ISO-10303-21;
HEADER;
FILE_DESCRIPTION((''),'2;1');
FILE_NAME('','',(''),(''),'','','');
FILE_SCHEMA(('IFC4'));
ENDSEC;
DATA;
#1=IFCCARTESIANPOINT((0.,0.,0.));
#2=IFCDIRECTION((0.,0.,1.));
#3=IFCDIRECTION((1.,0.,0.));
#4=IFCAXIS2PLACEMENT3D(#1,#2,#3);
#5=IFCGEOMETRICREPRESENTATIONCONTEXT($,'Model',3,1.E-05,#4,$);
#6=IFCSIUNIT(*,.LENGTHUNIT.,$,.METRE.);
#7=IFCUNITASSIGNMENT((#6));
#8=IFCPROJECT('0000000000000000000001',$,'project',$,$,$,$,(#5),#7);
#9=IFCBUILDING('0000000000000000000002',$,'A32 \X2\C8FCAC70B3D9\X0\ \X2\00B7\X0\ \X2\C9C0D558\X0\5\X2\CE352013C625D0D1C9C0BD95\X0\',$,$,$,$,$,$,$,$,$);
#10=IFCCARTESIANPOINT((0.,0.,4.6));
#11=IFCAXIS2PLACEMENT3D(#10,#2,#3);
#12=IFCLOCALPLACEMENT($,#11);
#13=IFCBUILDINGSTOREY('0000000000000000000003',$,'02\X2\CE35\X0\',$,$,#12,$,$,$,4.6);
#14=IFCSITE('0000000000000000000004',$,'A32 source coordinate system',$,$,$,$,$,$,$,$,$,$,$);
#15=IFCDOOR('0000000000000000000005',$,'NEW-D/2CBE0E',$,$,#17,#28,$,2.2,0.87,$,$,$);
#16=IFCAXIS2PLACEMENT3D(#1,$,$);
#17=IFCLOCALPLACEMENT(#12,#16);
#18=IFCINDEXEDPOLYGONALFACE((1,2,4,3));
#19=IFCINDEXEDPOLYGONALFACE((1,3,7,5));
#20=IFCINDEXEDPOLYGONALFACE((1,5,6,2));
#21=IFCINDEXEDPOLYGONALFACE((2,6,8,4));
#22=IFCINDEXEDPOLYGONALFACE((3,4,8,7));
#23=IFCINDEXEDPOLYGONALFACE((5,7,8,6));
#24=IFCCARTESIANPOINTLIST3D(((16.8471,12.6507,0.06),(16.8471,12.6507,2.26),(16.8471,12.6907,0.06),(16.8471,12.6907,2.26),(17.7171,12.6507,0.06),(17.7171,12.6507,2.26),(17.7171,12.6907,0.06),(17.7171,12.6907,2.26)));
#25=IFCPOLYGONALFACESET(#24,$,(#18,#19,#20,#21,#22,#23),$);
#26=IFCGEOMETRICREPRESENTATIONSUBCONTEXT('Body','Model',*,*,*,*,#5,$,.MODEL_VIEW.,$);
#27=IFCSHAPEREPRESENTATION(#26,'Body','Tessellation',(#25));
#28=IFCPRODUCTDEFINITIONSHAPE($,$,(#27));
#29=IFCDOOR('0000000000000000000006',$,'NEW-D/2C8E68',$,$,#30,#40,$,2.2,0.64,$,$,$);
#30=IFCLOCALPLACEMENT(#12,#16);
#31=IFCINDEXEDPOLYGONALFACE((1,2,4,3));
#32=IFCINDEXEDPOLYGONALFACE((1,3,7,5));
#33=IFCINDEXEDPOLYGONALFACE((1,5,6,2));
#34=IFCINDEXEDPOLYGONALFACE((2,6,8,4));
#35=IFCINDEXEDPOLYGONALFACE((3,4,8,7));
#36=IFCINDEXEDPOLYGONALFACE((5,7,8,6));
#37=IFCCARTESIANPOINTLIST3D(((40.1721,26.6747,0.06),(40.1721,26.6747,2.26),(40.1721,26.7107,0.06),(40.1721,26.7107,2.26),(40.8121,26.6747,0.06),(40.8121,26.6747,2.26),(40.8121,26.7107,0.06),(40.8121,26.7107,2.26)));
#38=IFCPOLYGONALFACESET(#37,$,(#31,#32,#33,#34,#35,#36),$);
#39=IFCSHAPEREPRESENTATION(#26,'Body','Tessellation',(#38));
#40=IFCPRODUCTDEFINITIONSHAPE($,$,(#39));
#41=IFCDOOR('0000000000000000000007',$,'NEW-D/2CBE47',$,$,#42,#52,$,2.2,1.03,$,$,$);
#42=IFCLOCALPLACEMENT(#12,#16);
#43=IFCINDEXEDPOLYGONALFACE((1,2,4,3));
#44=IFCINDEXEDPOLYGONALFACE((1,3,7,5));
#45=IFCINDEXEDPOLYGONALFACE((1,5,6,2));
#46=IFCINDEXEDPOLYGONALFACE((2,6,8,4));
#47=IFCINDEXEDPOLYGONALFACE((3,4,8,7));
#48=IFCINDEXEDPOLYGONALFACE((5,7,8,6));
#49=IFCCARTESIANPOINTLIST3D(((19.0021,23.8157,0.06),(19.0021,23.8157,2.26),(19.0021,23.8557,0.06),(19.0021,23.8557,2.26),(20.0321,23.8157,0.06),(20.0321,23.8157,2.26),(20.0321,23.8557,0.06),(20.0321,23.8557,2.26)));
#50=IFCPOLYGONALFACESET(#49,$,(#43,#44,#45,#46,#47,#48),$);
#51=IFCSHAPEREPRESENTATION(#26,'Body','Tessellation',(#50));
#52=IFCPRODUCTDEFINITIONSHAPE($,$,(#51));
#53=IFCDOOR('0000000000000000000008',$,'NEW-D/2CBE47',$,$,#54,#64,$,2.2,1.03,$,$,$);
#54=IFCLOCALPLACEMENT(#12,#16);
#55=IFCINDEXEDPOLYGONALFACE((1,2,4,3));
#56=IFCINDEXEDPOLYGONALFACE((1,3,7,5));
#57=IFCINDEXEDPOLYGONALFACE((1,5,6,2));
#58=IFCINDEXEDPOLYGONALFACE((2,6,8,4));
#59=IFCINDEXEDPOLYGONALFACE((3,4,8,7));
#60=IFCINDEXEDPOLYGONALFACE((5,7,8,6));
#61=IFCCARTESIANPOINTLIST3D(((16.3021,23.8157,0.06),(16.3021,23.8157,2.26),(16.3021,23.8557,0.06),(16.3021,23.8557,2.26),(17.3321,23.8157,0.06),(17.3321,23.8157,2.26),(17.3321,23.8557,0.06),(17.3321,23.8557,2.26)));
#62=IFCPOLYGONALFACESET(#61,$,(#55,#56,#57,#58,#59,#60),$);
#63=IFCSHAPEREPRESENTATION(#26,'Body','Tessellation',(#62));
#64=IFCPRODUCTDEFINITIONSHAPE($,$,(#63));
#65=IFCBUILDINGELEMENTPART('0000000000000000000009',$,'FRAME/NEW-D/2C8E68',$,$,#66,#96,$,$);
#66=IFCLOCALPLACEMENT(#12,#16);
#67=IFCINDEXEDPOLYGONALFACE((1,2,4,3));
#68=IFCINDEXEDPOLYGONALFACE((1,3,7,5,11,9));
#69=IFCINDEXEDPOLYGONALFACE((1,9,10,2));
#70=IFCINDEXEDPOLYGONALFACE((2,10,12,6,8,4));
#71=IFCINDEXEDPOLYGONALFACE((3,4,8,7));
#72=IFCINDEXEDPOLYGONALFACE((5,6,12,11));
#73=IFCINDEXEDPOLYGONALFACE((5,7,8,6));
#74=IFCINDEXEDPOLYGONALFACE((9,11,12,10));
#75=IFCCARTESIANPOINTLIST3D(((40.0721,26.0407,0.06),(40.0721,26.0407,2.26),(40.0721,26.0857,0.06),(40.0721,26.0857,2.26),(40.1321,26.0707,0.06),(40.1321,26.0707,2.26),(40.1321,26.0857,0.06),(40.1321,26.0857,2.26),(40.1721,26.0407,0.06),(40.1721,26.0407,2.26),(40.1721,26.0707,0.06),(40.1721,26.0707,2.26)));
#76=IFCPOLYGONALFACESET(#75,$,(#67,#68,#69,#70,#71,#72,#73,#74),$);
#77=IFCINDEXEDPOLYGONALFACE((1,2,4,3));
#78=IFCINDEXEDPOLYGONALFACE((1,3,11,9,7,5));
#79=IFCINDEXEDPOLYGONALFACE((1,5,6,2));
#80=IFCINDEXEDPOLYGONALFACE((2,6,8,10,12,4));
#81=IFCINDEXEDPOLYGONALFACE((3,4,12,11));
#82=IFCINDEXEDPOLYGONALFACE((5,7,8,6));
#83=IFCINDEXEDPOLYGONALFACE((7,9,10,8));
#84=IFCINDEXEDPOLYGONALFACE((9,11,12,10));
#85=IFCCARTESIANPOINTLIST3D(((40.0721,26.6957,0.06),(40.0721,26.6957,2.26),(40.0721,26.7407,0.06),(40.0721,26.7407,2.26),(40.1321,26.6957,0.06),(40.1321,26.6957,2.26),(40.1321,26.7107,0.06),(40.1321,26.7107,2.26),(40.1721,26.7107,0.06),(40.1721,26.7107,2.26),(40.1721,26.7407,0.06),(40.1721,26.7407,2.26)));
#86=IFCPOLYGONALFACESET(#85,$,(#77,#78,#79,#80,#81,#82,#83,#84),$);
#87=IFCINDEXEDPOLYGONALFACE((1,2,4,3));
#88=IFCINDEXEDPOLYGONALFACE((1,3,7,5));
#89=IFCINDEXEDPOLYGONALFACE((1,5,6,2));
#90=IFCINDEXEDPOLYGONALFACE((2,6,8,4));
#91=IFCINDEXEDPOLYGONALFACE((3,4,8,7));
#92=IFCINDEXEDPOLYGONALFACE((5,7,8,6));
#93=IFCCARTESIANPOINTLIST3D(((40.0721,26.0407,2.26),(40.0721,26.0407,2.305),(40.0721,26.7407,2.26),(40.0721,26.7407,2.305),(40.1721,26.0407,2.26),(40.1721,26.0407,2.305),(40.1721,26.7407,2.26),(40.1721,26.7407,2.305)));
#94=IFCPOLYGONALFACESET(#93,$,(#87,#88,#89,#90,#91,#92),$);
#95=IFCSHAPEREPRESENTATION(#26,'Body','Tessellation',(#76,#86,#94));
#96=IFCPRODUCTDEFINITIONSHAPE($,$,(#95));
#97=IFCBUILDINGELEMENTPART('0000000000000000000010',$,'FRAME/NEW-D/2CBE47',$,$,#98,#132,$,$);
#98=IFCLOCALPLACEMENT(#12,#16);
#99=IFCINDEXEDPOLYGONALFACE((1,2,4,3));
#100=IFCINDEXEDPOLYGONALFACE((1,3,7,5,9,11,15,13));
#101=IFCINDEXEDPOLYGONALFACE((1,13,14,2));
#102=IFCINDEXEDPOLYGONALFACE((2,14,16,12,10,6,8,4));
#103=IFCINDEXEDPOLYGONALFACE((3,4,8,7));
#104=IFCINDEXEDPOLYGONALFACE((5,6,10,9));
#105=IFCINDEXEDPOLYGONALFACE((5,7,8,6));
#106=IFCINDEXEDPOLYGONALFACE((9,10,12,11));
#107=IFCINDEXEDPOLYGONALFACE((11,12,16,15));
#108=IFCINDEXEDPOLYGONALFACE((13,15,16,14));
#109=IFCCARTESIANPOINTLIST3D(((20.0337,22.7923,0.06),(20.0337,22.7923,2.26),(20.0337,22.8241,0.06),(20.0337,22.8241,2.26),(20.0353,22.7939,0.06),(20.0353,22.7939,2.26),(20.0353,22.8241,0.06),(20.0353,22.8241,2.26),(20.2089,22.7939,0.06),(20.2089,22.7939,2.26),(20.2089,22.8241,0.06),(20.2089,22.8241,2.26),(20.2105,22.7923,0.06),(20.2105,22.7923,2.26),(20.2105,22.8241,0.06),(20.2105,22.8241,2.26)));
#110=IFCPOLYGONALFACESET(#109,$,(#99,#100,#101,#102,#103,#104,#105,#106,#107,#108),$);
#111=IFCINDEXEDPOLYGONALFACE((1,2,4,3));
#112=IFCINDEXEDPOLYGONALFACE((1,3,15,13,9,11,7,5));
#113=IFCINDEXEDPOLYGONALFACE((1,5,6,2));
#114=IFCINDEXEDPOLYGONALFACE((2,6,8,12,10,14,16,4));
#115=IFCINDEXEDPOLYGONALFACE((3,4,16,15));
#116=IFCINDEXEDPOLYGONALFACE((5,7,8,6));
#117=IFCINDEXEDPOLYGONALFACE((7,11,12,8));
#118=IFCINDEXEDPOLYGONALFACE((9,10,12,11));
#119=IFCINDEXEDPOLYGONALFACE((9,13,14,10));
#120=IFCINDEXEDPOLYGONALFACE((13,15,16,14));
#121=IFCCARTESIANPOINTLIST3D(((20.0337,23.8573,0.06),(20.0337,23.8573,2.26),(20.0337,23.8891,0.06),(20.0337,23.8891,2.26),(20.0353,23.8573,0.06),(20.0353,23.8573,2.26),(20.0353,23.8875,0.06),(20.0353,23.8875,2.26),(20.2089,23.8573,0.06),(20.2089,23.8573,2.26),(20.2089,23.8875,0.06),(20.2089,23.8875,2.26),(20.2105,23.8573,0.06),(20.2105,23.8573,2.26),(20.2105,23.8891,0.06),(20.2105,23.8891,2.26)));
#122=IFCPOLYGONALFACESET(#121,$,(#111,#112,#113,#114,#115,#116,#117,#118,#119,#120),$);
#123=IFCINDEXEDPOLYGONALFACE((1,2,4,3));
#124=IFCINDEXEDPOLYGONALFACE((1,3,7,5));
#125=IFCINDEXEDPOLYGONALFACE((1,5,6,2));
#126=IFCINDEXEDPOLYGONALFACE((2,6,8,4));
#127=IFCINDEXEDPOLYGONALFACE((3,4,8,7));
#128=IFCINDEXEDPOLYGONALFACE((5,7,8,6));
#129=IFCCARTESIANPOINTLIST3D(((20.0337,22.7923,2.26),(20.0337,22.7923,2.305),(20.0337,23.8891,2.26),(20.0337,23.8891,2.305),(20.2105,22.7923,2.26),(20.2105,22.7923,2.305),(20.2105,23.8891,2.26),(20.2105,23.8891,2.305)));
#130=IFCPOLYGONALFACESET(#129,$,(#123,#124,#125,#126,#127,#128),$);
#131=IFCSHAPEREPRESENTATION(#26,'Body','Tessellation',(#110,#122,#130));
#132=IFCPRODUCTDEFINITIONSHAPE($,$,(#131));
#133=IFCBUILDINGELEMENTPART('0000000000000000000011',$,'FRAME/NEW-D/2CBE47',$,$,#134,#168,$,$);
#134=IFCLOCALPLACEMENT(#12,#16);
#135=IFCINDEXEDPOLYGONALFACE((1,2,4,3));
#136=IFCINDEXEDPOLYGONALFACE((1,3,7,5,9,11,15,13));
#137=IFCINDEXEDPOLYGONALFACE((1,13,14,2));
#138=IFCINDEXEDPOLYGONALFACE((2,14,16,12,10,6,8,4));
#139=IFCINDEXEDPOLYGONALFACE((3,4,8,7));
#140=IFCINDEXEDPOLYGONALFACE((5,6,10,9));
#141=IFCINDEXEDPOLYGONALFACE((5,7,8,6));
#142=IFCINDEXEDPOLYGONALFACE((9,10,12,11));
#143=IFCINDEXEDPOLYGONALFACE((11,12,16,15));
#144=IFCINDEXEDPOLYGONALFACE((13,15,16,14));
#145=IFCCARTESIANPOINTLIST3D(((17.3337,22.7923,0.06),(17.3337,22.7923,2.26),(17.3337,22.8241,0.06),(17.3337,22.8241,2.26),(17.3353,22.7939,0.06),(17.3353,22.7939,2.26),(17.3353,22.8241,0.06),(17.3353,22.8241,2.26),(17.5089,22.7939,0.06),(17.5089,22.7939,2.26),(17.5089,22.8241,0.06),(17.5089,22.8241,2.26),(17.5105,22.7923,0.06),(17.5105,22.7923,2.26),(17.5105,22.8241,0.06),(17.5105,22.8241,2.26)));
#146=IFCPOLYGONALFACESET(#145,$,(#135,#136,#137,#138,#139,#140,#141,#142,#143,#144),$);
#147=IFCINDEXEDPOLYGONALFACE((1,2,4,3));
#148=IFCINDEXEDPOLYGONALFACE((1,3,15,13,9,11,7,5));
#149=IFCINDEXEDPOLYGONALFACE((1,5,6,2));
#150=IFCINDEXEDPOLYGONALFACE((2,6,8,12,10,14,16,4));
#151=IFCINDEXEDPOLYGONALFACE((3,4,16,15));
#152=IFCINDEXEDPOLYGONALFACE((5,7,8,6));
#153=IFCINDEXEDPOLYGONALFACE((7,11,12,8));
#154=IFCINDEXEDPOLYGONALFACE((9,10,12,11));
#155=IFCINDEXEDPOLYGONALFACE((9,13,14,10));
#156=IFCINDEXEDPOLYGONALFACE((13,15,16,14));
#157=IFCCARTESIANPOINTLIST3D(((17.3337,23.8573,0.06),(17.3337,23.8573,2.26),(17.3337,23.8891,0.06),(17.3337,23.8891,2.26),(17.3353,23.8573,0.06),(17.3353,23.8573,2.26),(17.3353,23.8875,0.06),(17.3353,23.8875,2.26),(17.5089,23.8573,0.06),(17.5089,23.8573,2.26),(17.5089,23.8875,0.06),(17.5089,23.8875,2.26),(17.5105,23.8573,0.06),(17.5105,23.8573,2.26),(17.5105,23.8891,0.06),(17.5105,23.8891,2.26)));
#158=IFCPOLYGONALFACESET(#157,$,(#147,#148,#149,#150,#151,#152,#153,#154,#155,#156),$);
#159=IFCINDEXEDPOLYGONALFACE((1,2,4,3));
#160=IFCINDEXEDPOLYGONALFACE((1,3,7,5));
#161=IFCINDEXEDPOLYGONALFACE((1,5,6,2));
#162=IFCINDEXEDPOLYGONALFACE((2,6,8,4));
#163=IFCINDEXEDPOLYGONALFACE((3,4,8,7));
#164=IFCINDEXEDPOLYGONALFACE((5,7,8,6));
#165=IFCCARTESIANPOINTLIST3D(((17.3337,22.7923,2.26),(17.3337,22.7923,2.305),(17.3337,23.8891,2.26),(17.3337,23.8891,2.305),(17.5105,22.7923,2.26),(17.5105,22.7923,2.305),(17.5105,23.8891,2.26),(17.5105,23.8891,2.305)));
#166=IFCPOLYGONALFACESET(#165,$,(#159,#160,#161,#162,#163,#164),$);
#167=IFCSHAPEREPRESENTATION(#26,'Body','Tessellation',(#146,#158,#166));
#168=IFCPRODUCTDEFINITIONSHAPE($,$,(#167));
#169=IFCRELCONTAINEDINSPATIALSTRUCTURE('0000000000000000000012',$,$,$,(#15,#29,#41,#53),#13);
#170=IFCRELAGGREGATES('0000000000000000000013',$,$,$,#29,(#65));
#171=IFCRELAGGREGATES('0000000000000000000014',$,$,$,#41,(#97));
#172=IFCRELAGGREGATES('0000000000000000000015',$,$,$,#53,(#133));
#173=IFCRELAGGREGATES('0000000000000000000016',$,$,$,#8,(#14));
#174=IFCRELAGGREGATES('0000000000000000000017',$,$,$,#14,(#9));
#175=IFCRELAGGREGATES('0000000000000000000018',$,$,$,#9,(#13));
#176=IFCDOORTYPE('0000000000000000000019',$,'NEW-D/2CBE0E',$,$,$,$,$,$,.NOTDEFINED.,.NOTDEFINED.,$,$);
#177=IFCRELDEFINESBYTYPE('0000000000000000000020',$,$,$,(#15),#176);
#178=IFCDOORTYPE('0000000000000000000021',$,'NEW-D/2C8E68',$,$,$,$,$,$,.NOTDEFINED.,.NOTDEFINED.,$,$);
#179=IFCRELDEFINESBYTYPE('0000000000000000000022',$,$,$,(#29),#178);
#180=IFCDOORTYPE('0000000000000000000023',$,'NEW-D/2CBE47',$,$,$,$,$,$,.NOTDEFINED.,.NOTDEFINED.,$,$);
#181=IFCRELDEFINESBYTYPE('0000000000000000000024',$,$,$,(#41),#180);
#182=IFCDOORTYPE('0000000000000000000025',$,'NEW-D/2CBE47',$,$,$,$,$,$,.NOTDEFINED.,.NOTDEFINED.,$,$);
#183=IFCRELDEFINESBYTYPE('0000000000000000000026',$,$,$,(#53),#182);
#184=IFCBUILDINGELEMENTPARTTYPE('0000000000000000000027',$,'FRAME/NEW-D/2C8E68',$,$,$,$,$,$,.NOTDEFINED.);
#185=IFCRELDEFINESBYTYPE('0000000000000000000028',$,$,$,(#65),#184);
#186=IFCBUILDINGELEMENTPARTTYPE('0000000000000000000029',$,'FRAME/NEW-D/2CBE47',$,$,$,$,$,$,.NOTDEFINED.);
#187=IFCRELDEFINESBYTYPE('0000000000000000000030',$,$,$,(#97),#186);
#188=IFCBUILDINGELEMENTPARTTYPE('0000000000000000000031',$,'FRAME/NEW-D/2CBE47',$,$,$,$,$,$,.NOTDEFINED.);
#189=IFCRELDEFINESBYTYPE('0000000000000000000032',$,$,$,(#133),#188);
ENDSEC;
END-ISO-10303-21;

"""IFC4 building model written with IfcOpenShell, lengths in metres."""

from ifc_helpers import new_model, si_unit, frame, origin, origin_with_axes, place, context, subcontext, project, spatial, polyline, outline, extrude, source, transform, mapped, type_object, type_shapes, element, aggregate, save


model = new_model("IFC4")

# Units and contexts
model_context = context("Model", 3, precision=1e-05, world=origin_with_axes())
body_context = subcontext(model_context, "Body", "Model", "MODEL_VIEW")
ifc_project = project(units=[si_unit("LENGTHUNIT", "METRE")], contexts=[model_context])

# Site, building, storey
site = spatial("IfcSite", under=ifc_project, Name="A32 source coordinate system")
building = spatial("IfcBuilding", under=site, Name="A32 주거동 · 지하5층–옥탑지붕")
storey_placement = place(None, frame((0.0, 0.0, 4.6), z_axis=(0.0, 0.0, 1.0), x_axis=(1.0, 0.0, 0.0)))
storey = spatial("IfcBuildingStorey", under=building, at=storey_placement, Name="02층", Elevation=4.6)

# Doors
door_type_1 = type_object("IfcDoorType", Name="NEW-D/2CBE0E", OperationType="NOTDEFINED", PredefinedType="NOTDEFINED")
shared_shape_1 = source(origin(), body_context, "Body", "SweptSolid", [
    extrude(outline(polyline([(16.8471, 12.6907), (17.7171, 12.6907), (17.7171, 12.6507), (16.8471, 12.6507), (16.8471, 12.6907)])), frame((0.0, 0.0, 0.06)), (0.0, 0.0, 1.0), 2.2),
])
type_shapes(door_type_1, [shared_shape_1])
door_1_placement = place(storey_placement, origin_with_axes())
element("IfcDoor", 1, at=door_1_placement, inside=storey, type_object=door_type_1, Name="NEW-D/2CBE0E", OverallHeight=2.2, OverallWidth=0.87, context=body_context, shape_type="MappedRepresentation", body=[
    mapped(shared_shape_1, transform((0.0, 0.0, 0.0), scale=1.0)),
])
door_type_2 = type_object("IfcDoorType", Name="NEW-D/2C8E68", OperationType="NOTDEFINED", PredefinedType="NOTDEFINED")
shared_shape_2 = source(origin(), body_context, "Body", "SweptSolid", [
    extrude(outline(polyline([(40.8121, 26.6747), (40.1721, 26.6747), (40.1721, 26.7107), (40.8121, 26.7107), (40.8121, 26.6747)])), frame((0.0, 0.0, 0.06)), (0.0, 0.0, 1.0), 2.2),
])
type_shapes(door_type_2, [shared_shape_2])
door_2_placement = place(storey_placement, origin_with_axes())
door_2 = element("IfcDoor", 2, at=door_2_placement, inside=storey, type_object=door_type_2, Name="NEW-D/2C8E68", OverallHeight=2.2, OverallWidth=0.64, context=body_context, shape_type="MappedRepresentation", body=[
    mapped(shared_shape_2, transform((0.0, 0.0, 0.0), scale=1.0)),
])
door_type_3 = type_object("IfcDoorType", Name="NEW-D/2CBE47", OperationType="NOTDEFINED", PredefinedType="NOTDEFINED")
shared_shape_3 = source(origin(), body_context, "Body", "SweptSolid", [
    extrude(outline(polyline([(20.0321, 23.8557), (20.0321, 23.8157), (19.0021, 23.8157), (19.0021, 23.8557), (20.0321, 23.8557)])), frame((0.0, 0.0, 0.06)), (0.0, 0.0, 1.0), 2.2),
])
type_shapes(door_type_3, [shared_shape_3])
door_3_placement = place(storey_placement, origin_with_axes())
door_3 = element("IfcDoor", 3, at=door_3_placement, inside=storey, type_object=door_type_3, Name="NEW-D/2CBE47", OverallHeight=2.2, OverallWidth=1.03, context=body_context, shape_type="MappedRepresentation", body=[
    mapped(shared_shape_3, transform((0.0, 0.0, 0.0), scale=1.0)),
])
door_type_4 = type_object("IfcDoorType", Name="NEW-D/2CBE47", OperationType="NOTDEFINED", PredefinedType="NOTDEFINED")
shared_shape_4 = source(origin(), body_context, "Body", "SweptSolid", [
    extrude(outline(polyline([(17.3321, 23.8557), (17.3321, 23.8157), (16.3021, 23.8157), (16.3021, 23.8557), (17.3321, 23.8557)])), frame((0.0, 0.0, 0.06)), (0.0, 0.0, 1.0), 2.2),
])
type_shapes(door_type_4, [shared_shape_4])
door_4_placement = place(storey_placement, origin_with_axes())
door_4 = element("IfcDoor", 4, at=door_4_placement, inside=storey, type_object=door_type_4, Name="NEW-D/2CBE47", OverallHeight=2.2, OverallWidth=1.03, context=body_context, shape_type="MappedRepresentation", body=[
    mapped(shared_shape_4, transform((0.0, 0.0, 0.0), scale=1.0)),
])

# Building element parts
building_element_part_type_1 = type_object("IfcBuildingElementPartType", Name="FRAME/NEW-D/2C8E68", PredefinedType="NOTDEFINED")
shared_shape_5 = source(origin(), body_context, "Body", "SweptSolid", [
    extrude(outline(polyline([(40.0721, 26.0857), (40.1321, 26.0857), (40.1321, 26.0707), (40.1721, 26.0707), (40.1721, 26.0407), (40.0721, 26.0407), (40.0721, 26.0857)])), frame((0.0, 0.0, 0.06)), (0.0, 0.0, 1.0), 2.2),
    extrude(outline(polyline([(40.1321, 26.7107), (40.1321, 26.6957), (40.0721, 26.6957), (40.0721, 26.7407), (40.1721, 26.7407), (40.1721, 26.7107), (40.1321, 26.7107)])), frame((0.0, 0.0, 0.06)), (0.0, 0.0, 1.0), 2.2),
    extrude(outline(polyline([(40.1721, 26.0407), (40.1721, 26.7407), (40.0721, 26.7407), (40.0721, 26.0407), (40.1721, 26.0407)])), frame((0.0, 0.0, 2.26)), (0.0, 0.0, 1.0), 0.045),
])
type_shapes(building_element_part_type_1, [shared_shape_5])
building_element_part_1_placement = place(door_2_placement, origin_with_axes())
building_element_part_1 = element("IfcBuildingElementPart", 5, at=building_element_part_1_placement, type_object=building_element_part_type_1, Name="FRAME/NEW-D/2C8E68", context=body_context, shape_type="MappedRepresentation", body=[
    mapped(shared_shape_5, transform((0.0, 0.0, 0.0), scale=1.0)),
])
aggregate(door_2, [building_element_part_1])
building_element_part_type_2 = type_object("IfcBuildingElementPartType", Name="FRAME/NEW-D/2CBE47", PredefinedType="NOTDEFINED")
shared_shape_6 = source(origin(), body_context, "Body", "SweptSolid", [
    extrude(outline(polyline([(20.0353, 22.7939), (20.2089, 22.7939), (20.2089, 22.8241), (20.2105, 22.8241), (20.2105, 22.7923), (20.0337, 22.7923), (20.0337, 22.8241), (20.0353, 22.8241), (20.0353, 22.7939)])), frame((0.0, 0.0, 0.06)), (0.0, 0.0, 1.0), 2.2),
    extrude(outline(polyline([(20.2105, 23.8891), (20.2105, 23.8573), (20.2089, 23.8573), (20.2089, 23.8875), (20.0353, 23.8875), (20.0353, 23.8573), (20.0337, 23.8573), (20.0337, 23.8891), (20.2105, 23.8891)])), frame((0.0, 0.0, 0.06)), (0.0, 0.0, 1.0), 2.2),
    extrude(outline(polyline([(20.2105, 22.7923), (20.2105, 23.8891), (20.0337, 23.8891), (20.0337, 22.7923), (20.2105, 22.7923)])), frame((0.0, 0.0, 2.26)), (0.0, 0.0, 1.0), 0.045),
])
type_shapes(building_element_part_type_2, [shared_shape_6])
building_element_part_2_placement = place(door_3_placement, origin_with_axes())
building_element_part_2 = element("IfcBuildingElementPart", 6, at=building_element_part_2_placement, type_object=building_element_part_type_2, Name="FRAME/NEW-D/2CBE47", context=body_context, shape_type="MappedRepresentation", body=[
    mapped(shared_shape_6, transform((0.0, 0.0, 0.0), scale=1.0)),
])
aggregate(door_3, [building_element_part_2])
building_element_part_type_3 = type_object("IfcBuildingElementPartType", Name="FRAME/NEW-D/2CBE47", PredefinedType="NOTDEFINED")
shared_shape_7 = source(origin(), body_context, "Body", "SweptSolid", [
    extrude(outline(polyline([(17.3353, 22.7939), (17.5089, 22.7939), (17.5089, 22.8241), (17.5105, 22.8241), (17.5105, 22.7923), (17.3337, 22.7923), (17.3337, 22.8241), (17.3353, 22.8241), (17.3353, 22.7939)])), frame((0.0, 0.0, 0.06)), (0.0, 0.0, 1.0), 2.2),
    extrude(outline(polyline([(17.5105, 23.8891), (17.5105, 23.8573), (17.5089, 23.8573), (17.5089, 23.8875), (17.3353, 23.8875), (17.3353, 23.8573), (17.3337, 23.8573), (17.3337, 23.8891), (17.5105, 23.8891)])), frame((0.0, 0.0, 0.06)), (0.0, 0.0, 1.0), 2.2),
    extrude(outline(polyline([(17.5105, 22.7923), (17.5105, 23.8891), (17.3337, 23.8891), (17.3337, 22.7923), (17.5105, 22.7923)])), frame((0.0, 0.0, 2.26)), (0.0, 0.0, 1.0), 0.045),
])
type_shapes(building_element_part_type_3, [shared_shape_7])
building_element_part_3_placement = place(door_4_placement, origin_with_axes())
building_element_part_3 = element("IfcBuildingElementPart", 7, at=building_element_part_3_placement, type_object=building_element_part_type_3, Name="FRAME/NEW-D/2CBE47", context=body_context, shape_type="MappedRepresentation", body=[
    mapped(shared_shape_7, transform((0.0, 0.0, 0.0), scale=1.0)),
])
aggregate(door_4, [building_element_part_3])

save(model, "model.ifc")
